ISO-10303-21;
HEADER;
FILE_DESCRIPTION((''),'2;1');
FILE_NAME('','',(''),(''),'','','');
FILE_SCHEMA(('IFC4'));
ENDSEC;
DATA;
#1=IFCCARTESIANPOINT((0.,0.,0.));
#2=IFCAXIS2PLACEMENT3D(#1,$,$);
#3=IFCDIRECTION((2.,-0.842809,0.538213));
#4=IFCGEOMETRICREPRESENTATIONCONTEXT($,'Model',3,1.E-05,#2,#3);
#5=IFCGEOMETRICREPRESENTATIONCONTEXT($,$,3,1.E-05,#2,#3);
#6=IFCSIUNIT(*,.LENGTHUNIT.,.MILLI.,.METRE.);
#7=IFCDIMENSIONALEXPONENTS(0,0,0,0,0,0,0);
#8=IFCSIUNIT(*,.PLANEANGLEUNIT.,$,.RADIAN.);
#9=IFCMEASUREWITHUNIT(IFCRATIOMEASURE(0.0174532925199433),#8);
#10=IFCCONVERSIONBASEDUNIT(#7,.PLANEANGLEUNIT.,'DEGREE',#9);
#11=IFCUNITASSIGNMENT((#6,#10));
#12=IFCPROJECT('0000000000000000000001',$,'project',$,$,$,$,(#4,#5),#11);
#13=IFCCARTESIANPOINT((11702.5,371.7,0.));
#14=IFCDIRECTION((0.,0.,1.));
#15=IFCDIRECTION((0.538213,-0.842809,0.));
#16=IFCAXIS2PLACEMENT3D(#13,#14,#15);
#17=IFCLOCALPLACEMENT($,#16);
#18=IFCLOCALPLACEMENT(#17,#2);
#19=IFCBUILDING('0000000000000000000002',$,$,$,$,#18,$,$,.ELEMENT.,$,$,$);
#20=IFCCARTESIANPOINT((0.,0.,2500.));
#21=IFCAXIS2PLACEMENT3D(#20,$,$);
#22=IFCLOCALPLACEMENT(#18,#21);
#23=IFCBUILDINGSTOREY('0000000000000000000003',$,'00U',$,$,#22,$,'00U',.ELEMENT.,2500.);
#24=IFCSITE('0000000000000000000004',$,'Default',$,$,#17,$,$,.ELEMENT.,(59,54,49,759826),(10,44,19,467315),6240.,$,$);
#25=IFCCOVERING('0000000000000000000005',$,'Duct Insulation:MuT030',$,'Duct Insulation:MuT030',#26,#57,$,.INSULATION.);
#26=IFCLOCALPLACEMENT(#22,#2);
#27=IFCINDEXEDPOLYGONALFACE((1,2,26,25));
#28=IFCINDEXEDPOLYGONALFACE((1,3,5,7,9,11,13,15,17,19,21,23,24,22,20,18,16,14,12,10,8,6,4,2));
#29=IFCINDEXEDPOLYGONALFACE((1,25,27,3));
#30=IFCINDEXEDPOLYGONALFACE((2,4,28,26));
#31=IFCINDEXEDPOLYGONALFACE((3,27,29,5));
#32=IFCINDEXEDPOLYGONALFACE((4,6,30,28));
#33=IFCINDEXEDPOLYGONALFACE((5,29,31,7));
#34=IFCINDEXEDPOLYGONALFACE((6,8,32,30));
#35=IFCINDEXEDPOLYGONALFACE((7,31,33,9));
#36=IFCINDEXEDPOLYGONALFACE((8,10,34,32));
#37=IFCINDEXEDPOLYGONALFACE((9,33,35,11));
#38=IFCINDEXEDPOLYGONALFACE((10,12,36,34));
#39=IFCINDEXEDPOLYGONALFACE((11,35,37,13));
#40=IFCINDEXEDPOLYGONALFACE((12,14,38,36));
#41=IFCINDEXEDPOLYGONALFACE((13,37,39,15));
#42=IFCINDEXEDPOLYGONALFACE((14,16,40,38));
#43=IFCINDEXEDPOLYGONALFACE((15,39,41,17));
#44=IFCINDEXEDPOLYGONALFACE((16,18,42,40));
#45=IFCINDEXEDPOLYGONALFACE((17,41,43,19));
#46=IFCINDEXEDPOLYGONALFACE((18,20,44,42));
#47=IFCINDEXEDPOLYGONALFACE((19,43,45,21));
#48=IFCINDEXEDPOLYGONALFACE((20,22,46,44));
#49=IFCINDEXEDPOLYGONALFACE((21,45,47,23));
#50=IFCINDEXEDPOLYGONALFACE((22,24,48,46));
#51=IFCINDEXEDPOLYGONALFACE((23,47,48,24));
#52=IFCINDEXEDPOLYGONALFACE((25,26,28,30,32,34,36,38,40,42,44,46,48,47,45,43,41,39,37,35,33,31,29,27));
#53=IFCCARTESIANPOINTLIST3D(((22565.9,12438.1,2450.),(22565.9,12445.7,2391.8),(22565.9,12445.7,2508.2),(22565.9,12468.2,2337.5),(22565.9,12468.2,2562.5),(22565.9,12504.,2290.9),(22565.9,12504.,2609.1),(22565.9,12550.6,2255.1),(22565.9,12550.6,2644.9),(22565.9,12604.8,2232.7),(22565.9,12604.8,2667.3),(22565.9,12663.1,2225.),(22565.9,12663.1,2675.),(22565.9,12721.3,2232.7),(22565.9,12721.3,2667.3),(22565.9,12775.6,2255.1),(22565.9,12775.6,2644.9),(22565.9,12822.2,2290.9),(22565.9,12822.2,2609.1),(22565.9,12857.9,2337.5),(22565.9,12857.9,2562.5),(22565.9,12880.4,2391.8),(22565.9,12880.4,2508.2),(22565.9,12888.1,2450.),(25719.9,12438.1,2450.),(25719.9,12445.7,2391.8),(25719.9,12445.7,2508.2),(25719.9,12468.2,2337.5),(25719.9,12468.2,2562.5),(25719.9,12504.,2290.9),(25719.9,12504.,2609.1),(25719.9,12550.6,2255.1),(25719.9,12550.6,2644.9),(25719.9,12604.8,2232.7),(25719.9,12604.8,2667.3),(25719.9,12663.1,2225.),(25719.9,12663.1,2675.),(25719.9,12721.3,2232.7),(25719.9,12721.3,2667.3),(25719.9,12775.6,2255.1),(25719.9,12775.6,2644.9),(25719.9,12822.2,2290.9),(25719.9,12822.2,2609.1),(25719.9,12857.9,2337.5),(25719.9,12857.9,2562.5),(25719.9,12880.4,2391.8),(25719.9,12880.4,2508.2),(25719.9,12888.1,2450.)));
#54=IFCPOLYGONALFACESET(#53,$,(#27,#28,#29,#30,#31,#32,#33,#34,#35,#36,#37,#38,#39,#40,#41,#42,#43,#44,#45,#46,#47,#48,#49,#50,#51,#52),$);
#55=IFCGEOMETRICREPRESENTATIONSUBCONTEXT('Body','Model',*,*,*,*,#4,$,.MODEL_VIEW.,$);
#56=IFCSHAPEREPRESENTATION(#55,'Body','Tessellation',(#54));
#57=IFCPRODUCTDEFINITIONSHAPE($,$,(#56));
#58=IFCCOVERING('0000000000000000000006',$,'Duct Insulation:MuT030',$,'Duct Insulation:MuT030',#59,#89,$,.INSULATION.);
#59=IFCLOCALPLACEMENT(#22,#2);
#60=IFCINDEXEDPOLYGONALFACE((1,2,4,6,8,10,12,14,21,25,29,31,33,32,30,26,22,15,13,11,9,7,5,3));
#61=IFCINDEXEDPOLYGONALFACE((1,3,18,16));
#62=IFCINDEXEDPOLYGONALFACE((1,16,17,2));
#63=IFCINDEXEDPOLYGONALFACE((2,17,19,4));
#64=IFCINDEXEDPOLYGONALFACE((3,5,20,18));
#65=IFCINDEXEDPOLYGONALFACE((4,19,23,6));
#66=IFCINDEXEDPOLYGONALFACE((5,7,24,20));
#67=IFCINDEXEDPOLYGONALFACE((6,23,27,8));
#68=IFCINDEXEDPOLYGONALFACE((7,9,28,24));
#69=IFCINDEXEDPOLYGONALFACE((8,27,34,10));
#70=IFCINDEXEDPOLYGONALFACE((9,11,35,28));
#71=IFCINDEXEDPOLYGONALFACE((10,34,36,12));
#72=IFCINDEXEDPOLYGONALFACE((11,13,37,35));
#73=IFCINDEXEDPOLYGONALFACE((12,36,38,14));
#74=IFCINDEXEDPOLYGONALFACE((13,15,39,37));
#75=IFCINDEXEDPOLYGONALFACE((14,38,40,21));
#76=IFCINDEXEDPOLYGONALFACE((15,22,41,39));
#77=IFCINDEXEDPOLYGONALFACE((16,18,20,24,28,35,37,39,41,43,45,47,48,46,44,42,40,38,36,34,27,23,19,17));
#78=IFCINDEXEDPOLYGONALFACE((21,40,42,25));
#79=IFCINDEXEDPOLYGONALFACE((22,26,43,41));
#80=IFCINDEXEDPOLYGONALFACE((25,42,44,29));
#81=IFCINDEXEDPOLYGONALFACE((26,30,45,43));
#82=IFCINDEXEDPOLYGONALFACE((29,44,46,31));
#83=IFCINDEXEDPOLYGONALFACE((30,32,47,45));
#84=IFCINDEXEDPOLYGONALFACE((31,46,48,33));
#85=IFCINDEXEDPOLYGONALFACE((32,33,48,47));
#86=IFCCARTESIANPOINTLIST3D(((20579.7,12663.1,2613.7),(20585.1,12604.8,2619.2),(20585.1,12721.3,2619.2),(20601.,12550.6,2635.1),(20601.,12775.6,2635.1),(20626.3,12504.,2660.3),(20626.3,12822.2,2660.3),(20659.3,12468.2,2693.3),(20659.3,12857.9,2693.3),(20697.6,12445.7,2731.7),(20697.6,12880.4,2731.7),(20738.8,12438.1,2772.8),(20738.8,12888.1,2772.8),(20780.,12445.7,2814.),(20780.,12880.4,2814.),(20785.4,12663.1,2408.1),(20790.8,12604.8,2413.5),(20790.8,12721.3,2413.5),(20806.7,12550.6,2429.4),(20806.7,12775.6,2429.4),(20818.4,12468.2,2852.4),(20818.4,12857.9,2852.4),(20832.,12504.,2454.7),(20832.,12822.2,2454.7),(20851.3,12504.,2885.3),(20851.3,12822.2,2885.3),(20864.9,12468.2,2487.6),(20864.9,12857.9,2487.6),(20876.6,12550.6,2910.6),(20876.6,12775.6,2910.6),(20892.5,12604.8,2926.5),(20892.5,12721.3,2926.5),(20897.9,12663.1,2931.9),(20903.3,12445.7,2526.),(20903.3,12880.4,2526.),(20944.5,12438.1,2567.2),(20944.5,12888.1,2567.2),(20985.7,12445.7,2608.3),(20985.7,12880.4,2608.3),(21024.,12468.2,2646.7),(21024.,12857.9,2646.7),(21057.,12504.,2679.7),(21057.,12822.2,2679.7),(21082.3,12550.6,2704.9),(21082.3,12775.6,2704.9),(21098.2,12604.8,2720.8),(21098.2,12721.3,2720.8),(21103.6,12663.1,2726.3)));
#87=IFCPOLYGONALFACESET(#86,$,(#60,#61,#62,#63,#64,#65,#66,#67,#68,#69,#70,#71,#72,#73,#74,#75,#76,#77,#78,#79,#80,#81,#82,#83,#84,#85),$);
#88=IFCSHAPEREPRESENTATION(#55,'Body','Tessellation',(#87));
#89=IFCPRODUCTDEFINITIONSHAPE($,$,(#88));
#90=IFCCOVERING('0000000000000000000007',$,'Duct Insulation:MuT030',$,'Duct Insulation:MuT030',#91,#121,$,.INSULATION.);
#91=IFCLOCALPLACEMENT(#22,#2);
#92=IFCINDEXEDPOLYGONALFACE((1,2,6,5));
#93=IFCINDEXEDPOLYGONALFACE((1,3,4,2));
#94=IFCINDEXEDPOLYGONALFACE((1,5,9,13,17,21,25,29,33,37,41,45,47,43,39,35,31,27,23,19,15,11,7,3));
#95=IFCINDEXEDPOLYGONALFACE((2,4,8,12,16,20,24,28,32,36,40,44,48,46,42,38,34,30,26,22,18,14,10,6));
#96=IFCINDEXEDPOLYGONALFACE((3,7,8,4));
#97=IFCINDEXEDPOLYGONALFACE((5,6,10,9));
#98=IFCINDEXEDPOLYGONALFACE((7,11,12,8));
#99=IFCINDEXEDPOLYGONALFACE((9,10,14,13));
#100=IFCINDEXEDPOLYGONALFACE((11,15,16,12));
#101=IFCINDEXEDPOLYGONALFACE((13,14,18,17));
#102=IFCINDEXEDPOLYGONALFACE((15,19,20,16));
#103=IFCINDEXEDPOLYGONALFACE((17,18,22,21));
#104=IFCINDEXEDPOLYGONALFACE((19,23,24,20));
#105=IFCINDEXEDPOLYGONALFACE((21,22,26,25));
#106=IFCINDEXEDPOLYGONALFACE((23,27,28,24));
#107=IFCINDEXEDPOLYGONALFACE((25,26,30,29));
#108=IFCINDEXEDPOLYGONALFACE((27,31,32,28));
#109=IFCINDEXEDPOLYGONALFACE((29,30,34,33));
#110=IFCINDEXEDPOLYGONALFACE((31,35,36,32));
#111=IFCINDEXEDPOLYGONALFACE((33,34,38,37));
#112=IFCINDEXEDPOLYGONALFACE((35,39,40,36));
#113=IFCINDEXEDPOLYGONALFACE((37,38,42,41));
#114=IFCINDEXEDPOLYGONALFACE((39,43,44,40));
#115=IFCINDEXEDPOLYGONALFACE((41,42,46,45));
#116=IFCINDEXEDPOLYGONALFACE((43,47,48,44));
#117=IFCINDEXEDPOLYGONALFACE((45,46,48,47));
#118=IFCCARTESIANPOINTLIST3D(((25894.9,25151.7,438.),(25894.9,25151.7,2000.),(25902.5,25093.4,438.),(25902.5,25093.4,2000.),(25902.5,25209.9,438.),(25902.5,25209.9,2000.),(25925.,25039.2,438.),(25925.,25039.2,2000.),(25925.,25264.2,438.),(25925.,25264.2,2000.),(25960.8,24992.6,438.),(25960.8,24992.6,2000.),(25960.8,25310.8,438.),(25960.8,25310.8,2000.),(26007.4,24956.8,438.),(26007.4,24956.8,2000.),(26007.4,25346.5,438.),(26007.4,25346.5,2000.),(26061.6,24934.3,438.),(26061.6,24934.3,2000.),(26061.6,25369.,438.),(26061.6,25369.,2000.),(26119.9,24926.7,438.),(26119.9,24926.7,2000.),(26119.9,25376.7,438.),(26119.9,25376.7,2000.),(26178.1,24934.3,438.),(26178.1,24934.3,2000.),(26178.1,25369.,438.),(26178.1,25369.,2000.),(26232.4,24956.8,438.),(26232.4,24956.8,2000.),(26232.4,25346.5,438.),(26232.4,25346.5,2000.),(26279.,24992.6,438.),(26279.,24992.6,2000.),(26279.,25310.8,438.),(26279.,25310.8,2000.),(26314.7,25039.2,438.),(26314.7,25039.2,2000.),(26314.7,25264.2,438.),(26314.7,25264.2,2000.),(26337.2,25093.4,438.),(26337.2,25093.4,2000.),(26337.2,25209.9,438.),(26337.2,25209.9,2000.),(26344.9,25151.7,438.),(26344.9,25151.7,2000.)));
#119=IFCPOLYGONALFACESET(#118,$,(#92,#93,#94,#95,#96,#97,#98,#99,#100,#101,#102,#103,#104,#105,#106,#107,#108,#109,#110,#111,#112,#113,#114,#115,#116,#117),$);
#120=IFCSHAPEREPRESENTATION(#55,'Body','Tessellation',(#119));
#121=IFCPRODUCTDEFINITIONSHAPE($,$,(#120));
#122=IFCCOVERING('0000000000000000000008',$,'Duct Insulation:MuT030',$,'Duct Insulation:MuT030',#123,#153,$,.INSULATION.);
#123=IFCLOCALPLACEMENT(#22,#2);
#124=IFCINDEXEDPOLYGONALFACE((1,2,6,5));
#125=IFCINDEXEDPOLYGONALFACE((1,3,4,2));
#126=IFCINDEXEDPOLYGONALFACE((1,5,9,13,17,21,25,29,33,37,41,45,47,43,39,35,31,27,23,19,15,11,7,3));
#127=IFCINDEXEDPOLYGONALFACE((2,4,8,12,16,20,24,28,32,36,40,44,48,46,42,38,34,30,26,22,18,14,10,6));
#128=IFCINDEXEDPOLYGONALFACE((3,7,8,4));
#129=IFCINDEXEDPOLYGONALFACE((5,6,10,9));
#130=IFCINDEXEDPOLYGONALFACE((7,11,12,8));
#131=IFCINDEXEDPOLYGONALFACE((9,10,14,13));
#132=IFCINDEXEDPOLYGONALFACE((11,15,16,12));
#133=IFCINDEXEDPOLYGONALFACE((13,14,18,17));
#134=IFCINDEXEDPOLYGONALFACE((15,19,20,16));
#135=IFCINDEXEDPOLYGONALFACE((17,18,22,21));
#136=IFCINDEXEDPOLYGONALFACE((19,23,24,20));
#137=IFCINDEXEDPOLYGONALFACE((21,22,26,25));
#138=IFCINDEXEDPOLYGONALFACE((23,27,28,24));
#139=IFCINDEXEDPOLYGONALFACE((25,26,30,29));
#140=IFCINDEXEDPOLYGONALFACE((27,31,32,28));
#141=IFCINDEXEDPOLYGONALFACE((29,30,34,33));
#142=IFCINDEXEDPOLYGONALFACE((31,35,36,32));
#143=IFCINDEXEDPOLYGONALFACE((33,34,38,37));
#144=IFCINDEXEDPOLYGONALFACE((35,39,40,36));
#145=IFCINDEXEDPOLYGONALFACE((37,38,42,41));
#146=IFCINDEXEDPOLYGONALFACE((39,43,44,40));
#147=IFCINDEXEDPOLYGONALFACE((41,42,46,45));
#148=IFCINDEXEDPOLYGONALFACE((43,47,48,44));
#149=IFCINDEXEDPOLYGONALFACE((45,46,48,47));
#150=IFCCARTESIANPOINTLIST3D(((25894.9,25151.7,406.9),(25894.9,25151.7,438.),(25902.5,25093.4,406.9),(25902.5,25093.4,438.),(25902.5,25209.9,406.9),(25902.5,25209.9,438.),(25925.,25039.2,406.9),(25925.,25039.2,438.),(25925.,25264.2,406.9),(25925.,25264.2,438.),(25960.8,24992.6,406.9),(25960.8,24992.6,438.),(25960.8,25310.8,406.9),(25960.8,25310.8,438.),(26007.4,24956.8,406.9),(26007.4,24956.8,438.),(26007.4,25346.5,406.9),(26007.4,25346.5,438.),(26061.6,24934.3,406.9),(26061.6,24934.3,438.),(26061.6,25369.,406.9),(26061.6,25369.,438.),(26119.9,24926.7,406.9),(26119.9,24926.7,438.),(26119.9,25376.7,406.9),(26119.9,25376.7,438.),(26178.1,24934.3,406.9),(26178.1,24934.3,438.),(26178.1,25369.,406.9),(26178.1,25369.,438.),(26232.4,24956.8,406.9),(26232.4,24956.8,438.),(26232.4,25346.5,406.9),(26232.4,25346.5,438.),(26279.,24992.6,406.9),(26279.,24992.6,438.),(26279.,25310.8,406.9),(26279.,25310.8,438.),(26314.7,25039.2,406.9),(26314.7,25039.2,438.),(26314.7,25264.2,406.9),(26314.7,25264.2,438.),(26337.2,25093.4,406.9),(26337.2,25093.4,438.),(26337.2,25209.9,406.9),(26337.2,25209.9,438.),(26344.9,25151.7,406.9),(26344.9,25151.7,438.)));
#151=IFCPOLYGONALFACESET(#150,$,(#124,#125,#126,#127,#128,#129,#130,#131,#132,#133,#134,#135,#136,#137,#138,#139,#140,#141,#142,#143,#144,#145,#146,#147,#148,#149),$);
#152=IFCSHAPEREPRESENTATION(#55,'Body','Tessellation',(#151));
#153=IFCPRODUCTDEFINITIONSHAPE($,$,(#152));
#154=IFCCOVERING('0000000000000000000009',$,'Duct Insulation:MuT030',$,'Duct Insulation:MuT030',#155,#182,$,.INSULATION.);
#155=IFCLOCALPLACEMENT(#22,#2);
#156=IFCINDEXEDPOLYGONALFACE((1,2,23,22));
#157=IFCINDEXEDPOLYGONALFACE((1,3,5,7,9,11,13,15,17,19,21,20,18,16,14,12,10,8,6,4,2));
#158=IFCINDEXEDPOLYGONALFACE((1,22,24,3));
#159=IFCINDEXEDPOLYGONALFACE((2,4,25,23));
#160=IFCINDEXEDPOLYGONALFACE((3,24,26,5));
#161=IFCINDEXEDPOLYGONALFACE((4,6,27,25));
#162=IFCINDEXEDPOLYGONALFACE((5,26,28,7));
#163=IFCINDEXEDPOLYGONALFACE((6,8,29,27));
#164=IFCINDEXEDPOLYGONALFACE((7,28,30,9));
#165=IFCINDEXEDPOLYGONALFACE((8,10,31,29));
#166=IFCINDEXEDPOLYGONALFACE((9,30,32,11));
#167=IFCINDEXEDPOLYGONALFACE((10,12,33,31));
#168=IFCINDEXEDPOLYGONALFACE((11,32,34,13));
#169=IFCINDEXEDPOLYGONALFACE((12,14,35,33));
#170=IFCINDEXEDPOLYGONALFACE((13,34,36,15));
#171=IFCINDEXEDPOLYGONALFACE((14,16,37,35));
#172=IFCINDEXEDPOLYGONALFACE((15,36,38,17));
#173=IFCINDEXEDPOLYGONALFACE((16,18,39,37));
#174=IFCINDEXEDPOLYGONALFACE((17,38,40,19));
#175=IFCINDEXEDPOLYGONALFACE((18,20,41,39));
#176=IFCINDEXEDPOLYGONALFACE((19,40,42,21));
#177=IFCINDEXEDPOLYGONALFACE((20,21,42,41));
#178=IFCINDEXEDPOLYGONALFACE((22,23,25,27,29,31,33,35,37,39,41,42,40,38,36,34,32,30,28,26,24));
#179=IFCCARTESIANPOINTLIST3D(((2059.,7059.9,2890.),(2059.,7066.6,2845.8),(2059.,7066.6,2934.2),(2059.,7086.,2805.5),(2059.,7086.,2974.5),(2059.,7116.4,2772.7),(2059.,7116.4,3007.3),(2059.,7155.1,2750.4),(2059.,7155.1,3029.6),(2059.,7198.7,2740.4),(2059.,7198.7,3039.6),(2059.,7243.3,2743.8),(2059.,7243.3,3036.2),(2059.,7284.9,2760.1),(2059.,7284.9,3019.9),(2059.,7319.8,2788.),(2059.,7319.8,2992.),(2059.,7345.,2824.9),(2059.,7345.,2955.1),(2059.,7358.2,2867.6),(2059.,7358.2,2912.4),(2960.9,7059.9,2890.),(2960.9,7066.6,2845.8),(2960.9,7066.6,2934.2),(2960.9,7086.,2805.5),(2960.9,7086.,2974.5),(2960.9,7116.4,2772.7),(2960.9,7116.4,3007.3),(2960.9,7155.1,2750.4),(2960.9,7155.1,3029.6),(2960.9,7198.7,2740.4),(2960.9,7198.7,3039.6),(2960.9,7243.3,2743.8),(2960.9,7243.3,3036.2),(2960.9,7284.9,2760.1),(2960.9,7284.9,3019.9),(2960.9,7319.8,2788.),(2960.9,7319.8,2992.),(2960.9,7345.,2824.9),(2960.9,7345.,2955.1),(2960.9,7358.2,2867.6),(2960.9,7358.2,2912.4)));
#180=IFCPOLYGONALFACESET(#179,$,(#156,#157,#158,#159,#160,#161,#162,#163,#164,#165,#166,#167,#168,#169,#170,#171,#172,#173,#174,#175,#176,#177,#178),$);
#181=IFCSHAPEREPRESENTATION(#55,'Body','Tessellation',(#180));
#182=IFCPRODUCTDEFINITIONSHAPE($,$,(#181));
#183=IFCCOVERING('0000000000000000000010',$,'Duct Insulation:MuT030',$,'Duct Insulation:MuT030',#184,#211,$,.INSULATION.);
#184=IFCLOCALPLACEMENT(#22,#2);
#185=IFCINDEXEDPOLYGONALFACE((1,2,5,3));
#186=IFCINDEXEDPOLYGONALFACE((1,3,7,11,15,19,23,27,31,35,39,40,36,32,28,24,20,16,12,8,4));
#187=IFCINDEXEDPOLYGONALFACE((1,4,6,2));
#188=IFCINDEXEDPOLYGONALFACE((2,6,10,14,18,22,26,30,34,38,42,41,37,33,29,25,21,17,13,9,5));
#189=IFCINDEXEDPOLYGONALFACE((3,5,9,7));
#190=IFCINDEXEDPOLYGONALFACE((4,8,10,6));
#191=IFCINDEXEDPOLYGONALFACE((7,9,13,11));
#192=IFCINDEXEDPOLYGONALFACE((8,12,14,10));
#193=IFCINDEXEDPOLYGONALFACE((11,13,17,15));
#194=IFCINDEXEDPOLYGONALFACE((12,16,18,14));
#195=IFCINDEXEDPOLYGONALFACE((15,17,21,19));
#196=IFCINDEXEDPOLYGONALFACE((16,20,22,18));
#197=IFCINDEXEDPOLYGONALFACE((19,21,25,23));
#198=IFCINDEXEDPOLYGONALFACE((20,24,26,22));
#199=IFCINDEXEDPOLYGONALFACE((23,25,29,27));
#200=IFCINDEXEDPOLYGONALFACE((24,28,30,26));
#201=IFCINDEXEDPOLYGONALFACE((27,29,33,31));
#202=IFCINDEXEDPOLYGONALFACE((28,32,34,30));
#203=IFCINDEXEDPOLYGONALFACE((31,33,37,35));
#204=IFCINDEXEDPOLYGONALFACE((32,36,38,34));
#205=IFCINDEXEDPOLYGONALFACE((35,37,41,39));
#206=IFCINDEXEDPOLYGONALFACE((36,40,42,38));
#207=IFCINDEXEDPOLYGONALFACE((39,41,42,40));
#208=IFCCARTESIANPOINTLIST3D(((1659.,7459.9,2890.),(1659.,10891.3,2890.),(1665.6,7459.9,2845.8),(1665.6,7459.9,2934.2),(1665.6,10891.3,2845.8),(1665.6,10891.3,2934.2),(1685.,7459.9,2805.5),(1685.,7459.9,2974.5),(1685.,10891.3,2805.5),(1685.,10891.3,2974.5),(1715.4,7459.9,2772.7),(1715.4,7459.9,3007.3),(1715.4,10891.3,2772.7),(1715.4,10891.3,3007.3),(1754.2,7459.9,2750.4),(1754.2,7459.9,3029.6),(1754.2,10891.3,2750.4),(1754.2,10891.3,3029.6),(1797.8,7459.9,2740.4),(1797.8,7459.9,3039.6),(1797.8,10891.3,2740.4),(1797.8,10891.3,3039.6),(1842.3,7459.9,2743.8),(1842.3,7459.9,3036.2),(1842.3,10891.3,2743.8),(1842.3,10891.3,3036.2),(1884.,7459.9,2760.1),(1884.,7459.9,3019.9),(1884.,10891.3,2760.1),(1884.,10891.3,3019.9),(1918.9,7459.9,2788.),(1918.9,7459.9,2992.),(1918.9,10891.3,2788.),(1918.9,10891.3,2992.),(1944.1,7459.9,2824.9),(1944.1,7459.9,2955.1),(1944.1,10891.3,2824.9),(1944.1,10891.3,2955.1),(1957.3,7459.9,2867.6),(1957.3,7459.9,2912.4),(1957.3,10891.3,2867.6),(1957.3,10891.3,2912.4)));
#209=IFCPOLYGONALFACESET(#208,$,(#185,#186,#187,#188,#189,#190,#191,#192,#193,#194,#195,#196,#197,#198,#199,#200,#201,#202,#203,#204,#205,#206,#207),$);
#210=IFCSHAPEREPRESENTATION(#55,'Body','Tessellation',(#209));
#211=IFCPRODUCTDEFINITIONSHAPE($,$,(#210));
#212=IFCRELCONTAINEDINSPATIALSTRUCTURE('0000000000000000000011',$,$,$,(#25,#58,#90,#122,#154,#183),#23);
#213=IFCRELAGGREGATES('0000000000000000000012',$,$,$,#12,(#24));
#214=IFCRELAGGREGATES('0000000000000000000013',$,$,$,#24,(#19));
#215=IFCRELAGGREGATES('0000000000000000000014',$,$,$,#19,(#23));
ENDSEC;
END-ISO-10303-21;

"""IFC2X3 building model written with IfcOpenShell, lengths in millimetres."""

from ifc_helpers import new_model, entity, si_unit, converted_unit, direction, frame, frame_2d, origin, origin_2d_with_axis, place, context, subcontext, project, spatial, circle, extrude, element, save


model = new_model("IFC2X3")

# Units and contexts
model_context = context("Model", 3, precision=1e-05, world=origin(), true_north=direction((2.0, -0.842809, 0.538213)))
context_of_model = context(None, 3, precision=1e-05, world=origin(), true_north=direction((2.0, -0.842809, 0.538213)))
body_context = subcontext(model_context, "Body", "Model", "MODEL_VIEW")
ifc_project = project(units=[si_unit("LENGTHUNIT", "METRE", prefix="MILLI"), converted_unit("PLANEANGLEUNIT", "DEGREE", entity("IfcRatioMeasure", 0.0174532925199433), si_unit("PLANEANGLEUNIT", "RADIAN"), dimensions=[0, 0, 0, 0, 0, 0, 0])], contexts=[model_context, context_of_model])

# Site, building, storey
site_placement = place(None, frame((11702.5, 371.7, 0.0), z_axis=(0.0, 0.0, 1.0), x_axis=(0.538213, -0.842809, 0.0)))
site = spatial("IfcSite", under=ifc_project, at=site_placement, Name="Default", CompositionType="ELEMENT", RefLatitude=(59, 54, 49, 759826), RefLongitude=(10, 44, 19, 467315), RefElevation=6240.0)
building_placement = place(site_placement, origin())
building = spatial("IfcBuilding", under=site, at=building_placement, CompositionType="ELEMENT")
storey_placement = place(building_placement, frame((0.0, 0.0, 2500.0)))
storey = spatial("IfcBuildingStorey", under=building, at=storey_placement, Name="00U", LongName="00U", CompositionType="ELEMENT", Elevation=2500.0)

# Coverings
covering_1_placement = place(storey_placement, origin())
element("IfcCovering", 1, at=covering_1_placement, inside=storey, Name="Duct Insulation:MuT030", ObjectType="Duct Insulation:MuT030", PredefinedType="INSULATION", context=body_context, shape_type="SweptSolid", body=[
    extrude(circle(Radius=225.0, at=origin_2d_with_axis()), frame((22565.9, 12663.1, 2450.0), z_axis=(1.0, 0.0, 0.0), x_axis=(0.0, -1.0, 0.0)), (0.0, 0.0, 1.0), 3154.0),
])
covering_2_placement = place(storey_placement, origin())
element("IfcCovering", 2, at=covering_2_placement, inside=storey, Name="Duct Insulation:MuT030", ObjectType="Duct Insulation:MuT030", PredefinedType="INSULATION", context=body_context, shape_type="SweptSolid", body=[
    extrude(circle(Radius=225.0, at=origin_2d_with_axis()), frame((20738.8, 12663.1, 2772.8), z_axis=(0.707107, 0.0, -0.707107), x_axis=(0.0, -1.0, 0.0)), (0.0, 0.0, 1.0), 290.9),
])
covering_3_placement = place(storey_placement, origin())
element("IfcCovering", 3, at=covering_3_placement, inside=storey, Name="Duct Insulation:MuT030", ObjectType="Duct Insulation:MuT030", PredefinedType="INSULATION", context=body_context, shape_type="SweptSolid", body=[
    extrude(circle(Radius=225.0, at=frame_2d((0.0, 0.0), x_axis=(1.0, 0.0))), frame((26119.9, 25151.7, 438.0)), (0.0, 0.0, 1.0), 1562.0),
])
covering_4_placement = place(storey_placement, origin())
element("IfcCovering", 4, at=covering_4_placement, inside=storey, Name="Duct Insulation:MuT030", ObjectType="Duct Insulation:MuT030", PredefinedType="INSULATION", context=body_context, shape_type="SweptSolid", body=[
    extrude(circle(Radius=225.0, at=origin_2d_with_axis()), frame((26119.9, 25151.7, 406.9), z_axis=(0.0, 0.0, 1.0), x_axis=(-1.0, 0.0, 0.0)), (0.0, 0.0, 1.0), 31.1),
])
covering_5_placement = place(storey_placement, origin())
element("IfcCovering", 5, at=covering_5_placement, inside=storey, Name="Duct Insulation:MuT030", ObjectType="Duct Insulation:MuT030", PredefinedType="INSULATION", context=body_context, shape_type="SweptSolid", body=[
    extrude(circle(Radius=150.0, at=origin_2d_with_axis()), frame((2059.0, 7209.9, 2890.0), z_axis=(1.0, 0.0, 0.0), x_axis=(0.0, -1.0, 0.0)), (0.0, 0.0, 1.0), 902.0),
])
covering_6_placement = place(storey_placement, origin())
element("IfcCovering", 6, at=covering_6_placement, inside=storey, Name="Duct Insulation:MuT030", ObjectType="Duct Insulation:MuT030", PredefinedType="INSULATION", context=body_context, shape_type="SweptSolid", body=[
    extrude(circle(Radius=150.0, at=frame_2d((0.0, 0.0), x_axis=(1.0, 0.0))), frame((1809.0, 7459.9, 2890.0), z_axis=(0.0, 1.0, 0.0), x_axis=(-1.0, 0.0, 0.0)), (0.0, 0.0, 1.0), 3431.4),
])

save(model, "model.ifc")
